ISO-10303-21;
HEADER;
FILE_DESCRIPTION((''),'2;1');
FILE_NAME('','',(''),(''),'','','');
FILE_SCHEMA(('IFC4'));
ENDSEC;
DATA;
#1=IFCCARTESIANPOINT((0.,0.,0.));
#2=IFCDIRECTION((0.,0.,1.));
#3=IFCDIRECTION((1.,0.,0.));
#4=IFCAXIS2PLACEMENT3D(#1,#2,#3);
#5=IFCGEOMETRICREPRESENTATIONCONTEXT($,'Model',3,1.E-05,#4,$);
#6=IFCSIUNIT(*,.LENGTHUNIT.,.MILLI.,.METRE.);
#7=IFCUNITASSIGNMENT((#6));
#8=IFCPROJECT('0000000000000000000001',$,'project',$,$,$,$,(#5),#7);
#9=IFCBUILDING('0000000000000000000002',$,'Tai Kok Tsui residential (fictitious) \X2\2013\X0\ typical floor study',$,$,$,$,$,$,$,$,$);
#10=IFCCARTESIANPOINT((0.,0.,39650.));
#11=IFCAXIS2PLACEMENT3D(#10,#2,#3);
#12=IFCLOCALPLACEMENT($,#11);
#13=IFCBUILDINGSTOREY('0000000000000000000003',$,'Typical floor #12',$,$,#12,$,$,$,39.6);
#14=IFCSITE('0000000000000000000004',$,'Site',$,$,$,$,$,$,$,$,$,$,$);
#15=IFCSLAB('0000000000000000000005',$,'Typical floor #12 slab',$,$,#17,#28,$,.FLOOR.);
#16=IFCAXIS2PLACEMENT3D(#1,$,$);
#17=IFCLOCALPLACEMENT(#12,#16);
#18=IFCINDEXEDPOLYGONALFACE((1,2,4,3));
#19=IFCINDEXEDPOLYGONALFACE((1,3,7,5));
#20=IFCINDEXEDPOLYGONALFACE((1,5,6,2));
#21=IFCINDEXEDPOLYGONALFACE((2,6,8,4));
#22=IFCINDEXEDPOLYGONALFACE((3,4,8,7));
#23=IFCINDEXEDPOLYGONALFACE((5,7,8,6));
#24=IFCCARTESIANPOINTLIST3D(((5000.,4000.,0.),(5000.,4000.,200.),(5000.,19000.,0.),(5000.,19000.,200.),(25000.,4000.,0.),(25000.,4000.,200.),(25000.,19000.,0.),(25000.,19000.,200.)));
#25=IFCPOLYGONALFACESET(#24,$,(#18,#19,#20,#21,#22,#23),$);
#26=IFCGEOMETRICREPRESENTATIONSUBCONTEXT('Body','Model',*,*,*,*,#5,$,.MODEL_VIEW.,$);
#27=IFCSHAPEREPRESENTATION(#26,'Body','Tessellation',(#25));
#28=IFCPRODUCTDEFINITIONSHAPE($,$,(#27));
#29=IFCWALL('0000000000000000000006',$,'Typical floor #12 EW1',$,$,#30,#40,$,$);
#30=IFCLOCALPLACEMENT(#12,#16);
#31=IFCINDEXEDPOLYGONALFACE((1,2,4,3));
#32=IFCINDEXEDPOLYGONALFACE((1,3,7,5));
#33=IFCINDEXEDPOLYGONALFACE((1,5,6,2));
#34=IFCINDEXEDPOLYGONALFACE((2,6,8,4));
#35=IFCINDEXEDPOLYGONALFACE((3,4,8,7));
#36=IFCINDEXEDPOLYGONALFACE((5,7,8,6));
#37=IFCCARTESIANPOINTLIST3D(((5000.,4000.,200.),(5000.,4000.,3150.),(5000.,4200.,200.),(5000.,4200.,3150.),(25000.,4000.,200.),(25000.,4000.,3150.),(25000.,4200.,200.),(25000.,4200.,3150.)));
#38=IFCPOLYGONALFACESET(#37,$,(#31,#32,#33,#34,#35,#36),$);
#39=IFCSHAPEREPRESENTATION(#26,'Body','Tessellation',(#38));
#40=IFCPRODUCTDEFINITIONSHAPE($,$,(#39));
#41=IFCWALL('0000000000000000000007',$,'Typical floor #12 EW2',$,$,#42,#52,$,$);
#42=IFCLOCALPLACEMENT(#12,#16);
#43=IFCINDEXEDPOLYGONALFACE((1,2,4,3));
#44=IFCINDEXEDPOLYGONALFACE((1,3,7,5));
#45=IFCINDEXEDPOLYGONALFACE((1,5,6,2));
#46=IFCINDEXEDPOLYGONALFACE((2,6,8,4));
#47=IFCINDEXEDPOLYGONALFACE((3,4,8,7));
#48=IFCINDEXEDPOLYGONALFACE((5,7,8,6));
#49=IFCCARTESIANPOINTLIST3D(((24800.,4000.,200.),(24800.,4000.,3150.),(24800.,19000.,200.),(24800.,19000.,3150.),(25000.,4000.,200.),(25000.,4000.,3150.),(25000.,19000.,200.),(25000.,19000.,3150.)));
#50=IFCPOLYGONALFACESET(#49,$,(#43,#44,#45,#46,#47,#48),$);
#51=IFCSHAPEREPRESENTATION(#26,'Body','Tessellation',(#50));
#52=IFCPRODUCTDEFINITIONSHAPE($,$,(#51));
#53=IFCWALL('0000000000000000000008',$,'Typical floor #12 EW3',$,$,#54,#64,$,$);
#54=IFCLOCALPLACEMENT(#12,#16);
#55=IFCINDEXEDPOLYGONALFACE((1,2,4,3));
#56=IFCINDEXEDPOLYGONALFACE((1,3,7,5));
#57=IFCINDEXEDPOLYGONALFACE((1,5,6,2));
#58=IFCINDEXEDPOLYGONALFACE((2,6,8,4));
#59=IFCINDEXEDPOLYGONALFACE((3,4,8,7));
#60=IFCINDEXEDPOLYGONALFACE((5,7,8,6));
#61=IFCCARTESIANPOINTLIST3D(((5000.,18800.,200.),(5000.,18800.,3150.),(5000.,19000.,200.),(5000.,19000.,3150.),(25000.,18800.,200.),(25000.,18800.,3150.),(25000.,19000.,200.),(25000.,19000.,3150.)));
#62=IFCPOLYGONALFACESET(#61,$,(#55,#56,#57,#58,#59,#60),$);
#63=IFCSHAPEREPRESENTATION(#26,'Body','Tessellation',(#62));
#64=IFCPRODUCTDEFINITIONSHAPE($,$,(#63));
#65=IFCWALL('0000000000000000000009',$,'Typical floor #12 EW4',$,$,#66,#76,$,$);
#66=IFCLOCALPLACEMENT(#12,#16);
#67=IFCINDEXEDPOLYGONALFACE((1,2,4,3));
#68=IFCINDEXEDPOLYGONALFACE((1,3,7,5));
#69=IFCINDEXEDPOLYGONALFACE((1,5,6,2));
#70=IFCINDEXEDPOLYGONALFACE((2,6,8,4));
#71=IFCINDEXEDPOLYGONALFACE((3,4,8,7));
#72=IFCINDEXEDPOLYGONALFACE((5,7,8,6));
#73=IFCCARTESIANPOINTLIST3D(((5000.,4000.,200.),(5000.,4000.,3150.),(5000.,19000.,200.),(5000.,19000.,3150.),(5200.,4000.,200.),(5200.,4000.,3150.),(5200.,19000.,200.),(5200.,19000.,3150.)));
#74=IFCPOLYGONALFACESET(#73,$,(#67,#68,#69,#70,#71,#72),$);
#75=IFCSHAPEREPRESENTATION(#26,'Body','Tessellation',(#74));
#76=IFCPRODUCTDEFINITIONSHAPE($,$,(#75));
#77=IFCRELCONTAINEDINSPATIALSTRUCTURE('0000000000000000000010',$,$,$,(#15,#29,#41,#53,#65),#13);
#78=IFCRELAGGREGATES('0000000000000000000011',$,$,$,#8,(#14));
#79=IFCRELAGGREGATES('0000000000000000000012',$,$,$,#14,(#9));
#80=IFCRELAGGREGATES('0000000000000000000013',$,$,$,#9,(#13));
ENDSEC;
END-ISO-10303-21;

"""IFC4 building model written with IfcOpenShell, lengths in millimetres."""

from ifc_helpers import new_model, si_unit, frame, origin_with_axes, place, context, subcontext, project, spatial, indexed_curve, outline, extrude, element, save


model = new_model("IFC4")

# Units and contexts
model_context = context("Model", 3, precision=1e-05, world=origin_with_axes())
body_context = subcontext(model_context, "Body", "Model", "MODEL_VIEW")
ifc_project = project(units=[si_unit("LENGTHUNIT", "METRE", prefix="MILLI")], contexts=[model_context])

# Site, building, storey
site = spatial("IfcSite", under=ifc_project, Name="Site")
building = spatial("IfcBuilding", under=site, Name="Tai Kok Tsui residential (fictitious) – typical floor study")
storey_placement = place(None, frame((0.0, 0.0, 39650.0), z_axis=(0.0, 0.0, 1.0), x_axis=(1.0, 0.0, 0.0)))
storey = spatial("IfcBuildingStorey", under=building, at=storey_placement, Name="Typical floor #12", Elevation=39.6)

# Slab
slab_placement = place(storey_placement, origin_with_axes())
element("IfcSlab", 1, at=slab_placement, inside=storey, Name="Typical floor #12 slab", PredefinedType="FLOOR", context=body_context, shape_type="SweptSolid", body=[
    extrude(outline(indexed_curve([(5000.0, 4000.0), (25000.0, 4000.0), (25000.0, 19000.0), (5000.0, 19000.0)])), None, (0.0, 0.0, 1.0), 200.0),
])

# Walls
wall_1_placement = place(storey_placement, frame((5000.0, 4000.0, 200.0), z_axis=(0.0, 0.0, 1.0), x_axis=(1.0, 0.0, 0.0)))
element("IfcWall", 2, at=wall_1_placement, inside=storey, Name="Typical floor #12 EW1", context=body_context, shape_type="SweptSolid", body=[
    extrude(outline(indexed_curve([(0.0, 0.0), (0.0, 200.0), (20000.0, 200.0), (20000.0, 0.0), (0.0, 0.0)], self_intersect=False)), origin_with_axes(), (0.0, 0.0, 1.0), 2950.0),
])
wall_2_placement = place(storey_placement, frame((25000.0, 4000.0, 200.0), z_axis=(0.0, 0.0, 1.0), x_axis=(0.0, 1.0, 0.0)))
element("IfcWall", 3, at=wall_2_placement, inside=storey, Name="Typical floor #12 EW2", context=body_context, shape_type="SweptSolid", body=[
    extrude(outline(indexed_curve([(0.0, 0.0), (0.0, 200.0), (15000.0, 200.0), (15000.0, 0.0), (0.0, 0.0)], self_intersect=False)), origin_with_axes(), (0.0, 0.0, 1.0), 2950.0),
])
wall_3_placement = place(storey_placement, frame((25000.0, 19000.0, 200.0), z_axis=(0.0, 0.0, 1.0), x_axis=(-1.0, 0.0, 0.0)))
element("IfcWall", 4, at=wall_3_placement, inside=storey, Name="Typical floor #12 EW3", context=body_context, shape_type="SweptSolid", body=[
    extrude(outline(indexed_curve([(0.0, 0.0), (0.0, 200.0), (20000.0, 200.0), (20000.0, 0.0), (0.0, 0.0)], self_intersect=False)), origin_with_axes(), (0.0, 0.0, 1.0), 2950.0),
])
wall_4_placement = place(storey_placement, frame((5000.0, 19000.0, 200.0), z_axis=(0.0, 0.0, 1.0), x_axis=(0.0, -1.0, 0.0)))
element("IfcWall", 5, at=wall_4_placement, inside=storey, Name="Typical floor #12 EW4", context=body_context, shape_type="SweptSolid", body=[
    extrude(outline(indexed_curve([(0.0, 0.0), (0.0, 200.0), (15000.0, 200.0), (15000.0, 0.0), (0.0, 0.0)], self_intersect=False)), origin_with_axes(), (0.0, 0.0, 1.0), 2950.0),
])

save(model, "model.ifc")
